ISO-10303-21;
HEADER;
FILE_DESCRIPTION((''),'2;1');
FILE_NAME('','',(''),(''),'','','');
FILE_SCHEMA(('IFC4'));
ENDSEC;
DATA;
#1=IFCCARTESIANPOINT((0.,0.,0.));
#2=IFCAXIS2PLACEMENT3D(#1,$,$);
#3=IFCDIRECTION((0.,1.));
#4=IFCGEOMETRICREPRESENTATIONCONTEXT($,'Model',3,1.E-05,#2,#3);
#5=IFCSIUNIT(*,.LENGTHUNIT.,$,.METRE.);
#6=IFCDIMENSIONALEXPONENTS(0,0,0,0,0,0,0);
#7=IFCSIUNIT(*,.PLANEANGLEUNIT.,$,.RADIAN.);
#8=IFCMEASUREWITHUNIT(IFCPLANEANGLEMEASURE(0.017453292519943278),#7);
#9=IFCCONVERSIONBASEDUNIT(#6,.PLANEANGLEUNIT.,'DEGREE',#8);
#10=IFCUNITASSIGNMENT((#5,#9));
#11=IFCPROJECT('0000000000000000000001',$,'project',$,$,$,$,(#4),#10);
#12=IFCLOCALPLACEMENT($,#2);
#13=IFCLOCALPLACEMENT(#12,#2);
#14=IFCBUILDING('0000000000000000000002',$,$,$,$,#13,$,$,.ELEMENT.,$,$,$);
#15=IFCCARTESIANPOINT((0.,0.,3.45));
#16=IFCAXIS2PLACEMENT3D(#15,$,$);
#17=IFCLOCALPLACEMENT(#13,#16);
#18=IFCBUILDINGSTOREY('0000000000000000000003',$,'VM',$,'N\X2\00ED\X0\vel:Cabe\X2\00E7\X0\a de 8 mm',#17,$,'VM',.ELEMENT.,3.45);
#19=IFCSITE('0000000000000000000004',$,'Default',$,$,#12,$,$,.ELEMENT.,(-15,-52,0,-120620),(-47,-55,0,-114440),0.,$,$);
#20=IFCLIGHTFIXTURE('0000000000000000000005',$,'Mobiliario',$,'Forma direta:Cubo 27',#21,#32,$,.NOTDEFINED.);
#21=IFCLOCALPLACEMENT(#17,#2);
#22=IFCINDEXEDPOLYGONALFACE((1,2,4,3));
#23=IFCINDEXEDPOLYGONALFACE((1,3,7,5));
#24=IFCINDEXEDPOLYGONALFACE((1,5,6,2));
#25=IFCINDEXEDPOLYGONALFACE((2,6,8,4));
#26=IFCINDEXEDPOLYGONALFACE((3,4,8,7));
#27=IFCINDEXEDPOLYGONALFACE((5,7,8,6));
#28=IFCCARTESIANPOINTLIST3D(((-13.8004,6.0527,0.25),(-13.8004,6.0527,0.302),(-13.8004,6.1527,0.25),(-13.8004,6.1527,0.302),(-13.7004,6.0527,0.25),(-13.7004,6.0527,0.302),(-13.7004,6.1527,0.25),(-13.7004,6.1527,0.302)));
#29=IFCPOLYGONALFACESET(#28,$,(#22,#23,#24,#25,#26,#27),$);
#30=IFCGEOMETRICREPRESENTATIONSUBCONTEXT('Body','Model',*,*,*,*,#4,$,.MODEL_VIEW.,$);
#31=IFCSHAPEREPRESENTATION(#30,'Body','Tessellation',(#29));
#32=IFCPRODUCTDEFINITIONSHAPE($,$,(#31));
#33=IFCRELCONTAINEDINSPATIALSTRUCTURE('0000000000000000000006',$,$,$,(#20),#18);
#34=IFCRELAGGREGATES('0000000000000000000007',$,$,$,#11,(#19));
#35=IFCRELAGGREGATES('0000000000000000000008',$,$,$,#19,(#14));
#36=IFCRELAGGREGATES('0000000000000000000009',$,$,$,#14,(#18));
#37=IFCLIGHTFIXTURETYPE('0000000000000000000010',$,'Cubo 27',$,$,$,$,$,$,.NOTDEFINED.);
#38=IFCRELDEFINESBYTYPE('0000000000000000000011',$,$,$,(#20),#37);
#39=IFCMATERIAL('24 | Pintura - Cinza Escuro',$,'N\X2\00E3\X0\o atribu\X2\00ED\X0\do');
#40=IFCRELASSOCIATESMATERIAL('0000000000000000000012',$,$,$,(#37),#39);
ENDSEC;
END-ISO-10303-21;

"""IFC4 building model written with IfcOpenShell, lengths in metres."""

from ifc_helpers import new_model, entity, si_unit, converted_unit, direction, frame, origin, place, context, subcontext, project, spatial, indexed_curve, outline, extrude, material, type_object, element, save


model = new_model("IFC4")

# Units and contexts
model_context = context("Model", 3, precision=1e-05, world=origin(), true_north=direction((0.0, 1.0)))
body_context = subcontext(model_context, "Body", "Model", "MODEL_VIEW")
ifc_project = project(units=[si_unit("LENGTHUNIT", "METRE"), converted_unit("PLANEANGLEUNIT", "DEGREE", entity("IfcPlaneAngleMeasure", 0.017453292519943278), si_unit("PLANEANGLEUNIT", "RADIAN"), dimensions=[0, 0, 0, 0, 0, 0, 0])], contexts=[model_context])

# Site, building, storey
site_placement = place(None, origin())
site = spatial("IfcSite", under=ifc_project, at=site_placement, Name="Default", CompositionType="ELEMENT", RefLatitude=(-15, -52, 0, -120620), RefLongitude=(-47, -55, 0, -114440), RefElevation=0.0)
building_placement = place(site_placement, origin())
building = spatial("IfcBuilding", under=site, at=building_placement, CompositionType="ELEMENT")
storey_placement = place(building_placement, frame((0.0, 0.0, 3.45)))
storey = spatial("IfcBuildingStorey", under=building, at=storey_placement, Name="VM", ObjectType="Nível:Cabeça de 8 mm", LongName="VM", CompositionType="ELEMENT", Elevation=3.45)

# Light fixture
ifc_material_1 = material(Name="24 | Pintura - Cinza Escuro", Category="Não atribuído")
light_fixture_type = type_object("IfcLightFixtureType", Name="Cubo 27", PredefinedType="NOTDEFINED", material=ifc_material_1)
light_fixture_1_placement = place(storey_placement, origin())
element("IfcLightFixture", 1, at=light_fixture_1_placement, inside=storey, type_object=light_fixture_type, Name="Mobiliario", ObjectType="Forma direta:Cubo 27", PredefinedType="NOTDEFINED", context=body_context, shape_type="SweptSolid", body=[
    extrude(outline(indexed_curve([(-0.05, -0.05), (0.05, -0.05), (0.05, 0.05), (-0.05, 0.05), (-0.05, -0.05)], self_intersect=False)), frame((-13.7504, 6.1027, 0.25), z_axis=(0.0, 0.0, 1.0), x_axis=(-0.000013, -1.0, 0.0)), (0.0, 0.0, 1.0), 0.052),
])

save(model, "model.ifc")
